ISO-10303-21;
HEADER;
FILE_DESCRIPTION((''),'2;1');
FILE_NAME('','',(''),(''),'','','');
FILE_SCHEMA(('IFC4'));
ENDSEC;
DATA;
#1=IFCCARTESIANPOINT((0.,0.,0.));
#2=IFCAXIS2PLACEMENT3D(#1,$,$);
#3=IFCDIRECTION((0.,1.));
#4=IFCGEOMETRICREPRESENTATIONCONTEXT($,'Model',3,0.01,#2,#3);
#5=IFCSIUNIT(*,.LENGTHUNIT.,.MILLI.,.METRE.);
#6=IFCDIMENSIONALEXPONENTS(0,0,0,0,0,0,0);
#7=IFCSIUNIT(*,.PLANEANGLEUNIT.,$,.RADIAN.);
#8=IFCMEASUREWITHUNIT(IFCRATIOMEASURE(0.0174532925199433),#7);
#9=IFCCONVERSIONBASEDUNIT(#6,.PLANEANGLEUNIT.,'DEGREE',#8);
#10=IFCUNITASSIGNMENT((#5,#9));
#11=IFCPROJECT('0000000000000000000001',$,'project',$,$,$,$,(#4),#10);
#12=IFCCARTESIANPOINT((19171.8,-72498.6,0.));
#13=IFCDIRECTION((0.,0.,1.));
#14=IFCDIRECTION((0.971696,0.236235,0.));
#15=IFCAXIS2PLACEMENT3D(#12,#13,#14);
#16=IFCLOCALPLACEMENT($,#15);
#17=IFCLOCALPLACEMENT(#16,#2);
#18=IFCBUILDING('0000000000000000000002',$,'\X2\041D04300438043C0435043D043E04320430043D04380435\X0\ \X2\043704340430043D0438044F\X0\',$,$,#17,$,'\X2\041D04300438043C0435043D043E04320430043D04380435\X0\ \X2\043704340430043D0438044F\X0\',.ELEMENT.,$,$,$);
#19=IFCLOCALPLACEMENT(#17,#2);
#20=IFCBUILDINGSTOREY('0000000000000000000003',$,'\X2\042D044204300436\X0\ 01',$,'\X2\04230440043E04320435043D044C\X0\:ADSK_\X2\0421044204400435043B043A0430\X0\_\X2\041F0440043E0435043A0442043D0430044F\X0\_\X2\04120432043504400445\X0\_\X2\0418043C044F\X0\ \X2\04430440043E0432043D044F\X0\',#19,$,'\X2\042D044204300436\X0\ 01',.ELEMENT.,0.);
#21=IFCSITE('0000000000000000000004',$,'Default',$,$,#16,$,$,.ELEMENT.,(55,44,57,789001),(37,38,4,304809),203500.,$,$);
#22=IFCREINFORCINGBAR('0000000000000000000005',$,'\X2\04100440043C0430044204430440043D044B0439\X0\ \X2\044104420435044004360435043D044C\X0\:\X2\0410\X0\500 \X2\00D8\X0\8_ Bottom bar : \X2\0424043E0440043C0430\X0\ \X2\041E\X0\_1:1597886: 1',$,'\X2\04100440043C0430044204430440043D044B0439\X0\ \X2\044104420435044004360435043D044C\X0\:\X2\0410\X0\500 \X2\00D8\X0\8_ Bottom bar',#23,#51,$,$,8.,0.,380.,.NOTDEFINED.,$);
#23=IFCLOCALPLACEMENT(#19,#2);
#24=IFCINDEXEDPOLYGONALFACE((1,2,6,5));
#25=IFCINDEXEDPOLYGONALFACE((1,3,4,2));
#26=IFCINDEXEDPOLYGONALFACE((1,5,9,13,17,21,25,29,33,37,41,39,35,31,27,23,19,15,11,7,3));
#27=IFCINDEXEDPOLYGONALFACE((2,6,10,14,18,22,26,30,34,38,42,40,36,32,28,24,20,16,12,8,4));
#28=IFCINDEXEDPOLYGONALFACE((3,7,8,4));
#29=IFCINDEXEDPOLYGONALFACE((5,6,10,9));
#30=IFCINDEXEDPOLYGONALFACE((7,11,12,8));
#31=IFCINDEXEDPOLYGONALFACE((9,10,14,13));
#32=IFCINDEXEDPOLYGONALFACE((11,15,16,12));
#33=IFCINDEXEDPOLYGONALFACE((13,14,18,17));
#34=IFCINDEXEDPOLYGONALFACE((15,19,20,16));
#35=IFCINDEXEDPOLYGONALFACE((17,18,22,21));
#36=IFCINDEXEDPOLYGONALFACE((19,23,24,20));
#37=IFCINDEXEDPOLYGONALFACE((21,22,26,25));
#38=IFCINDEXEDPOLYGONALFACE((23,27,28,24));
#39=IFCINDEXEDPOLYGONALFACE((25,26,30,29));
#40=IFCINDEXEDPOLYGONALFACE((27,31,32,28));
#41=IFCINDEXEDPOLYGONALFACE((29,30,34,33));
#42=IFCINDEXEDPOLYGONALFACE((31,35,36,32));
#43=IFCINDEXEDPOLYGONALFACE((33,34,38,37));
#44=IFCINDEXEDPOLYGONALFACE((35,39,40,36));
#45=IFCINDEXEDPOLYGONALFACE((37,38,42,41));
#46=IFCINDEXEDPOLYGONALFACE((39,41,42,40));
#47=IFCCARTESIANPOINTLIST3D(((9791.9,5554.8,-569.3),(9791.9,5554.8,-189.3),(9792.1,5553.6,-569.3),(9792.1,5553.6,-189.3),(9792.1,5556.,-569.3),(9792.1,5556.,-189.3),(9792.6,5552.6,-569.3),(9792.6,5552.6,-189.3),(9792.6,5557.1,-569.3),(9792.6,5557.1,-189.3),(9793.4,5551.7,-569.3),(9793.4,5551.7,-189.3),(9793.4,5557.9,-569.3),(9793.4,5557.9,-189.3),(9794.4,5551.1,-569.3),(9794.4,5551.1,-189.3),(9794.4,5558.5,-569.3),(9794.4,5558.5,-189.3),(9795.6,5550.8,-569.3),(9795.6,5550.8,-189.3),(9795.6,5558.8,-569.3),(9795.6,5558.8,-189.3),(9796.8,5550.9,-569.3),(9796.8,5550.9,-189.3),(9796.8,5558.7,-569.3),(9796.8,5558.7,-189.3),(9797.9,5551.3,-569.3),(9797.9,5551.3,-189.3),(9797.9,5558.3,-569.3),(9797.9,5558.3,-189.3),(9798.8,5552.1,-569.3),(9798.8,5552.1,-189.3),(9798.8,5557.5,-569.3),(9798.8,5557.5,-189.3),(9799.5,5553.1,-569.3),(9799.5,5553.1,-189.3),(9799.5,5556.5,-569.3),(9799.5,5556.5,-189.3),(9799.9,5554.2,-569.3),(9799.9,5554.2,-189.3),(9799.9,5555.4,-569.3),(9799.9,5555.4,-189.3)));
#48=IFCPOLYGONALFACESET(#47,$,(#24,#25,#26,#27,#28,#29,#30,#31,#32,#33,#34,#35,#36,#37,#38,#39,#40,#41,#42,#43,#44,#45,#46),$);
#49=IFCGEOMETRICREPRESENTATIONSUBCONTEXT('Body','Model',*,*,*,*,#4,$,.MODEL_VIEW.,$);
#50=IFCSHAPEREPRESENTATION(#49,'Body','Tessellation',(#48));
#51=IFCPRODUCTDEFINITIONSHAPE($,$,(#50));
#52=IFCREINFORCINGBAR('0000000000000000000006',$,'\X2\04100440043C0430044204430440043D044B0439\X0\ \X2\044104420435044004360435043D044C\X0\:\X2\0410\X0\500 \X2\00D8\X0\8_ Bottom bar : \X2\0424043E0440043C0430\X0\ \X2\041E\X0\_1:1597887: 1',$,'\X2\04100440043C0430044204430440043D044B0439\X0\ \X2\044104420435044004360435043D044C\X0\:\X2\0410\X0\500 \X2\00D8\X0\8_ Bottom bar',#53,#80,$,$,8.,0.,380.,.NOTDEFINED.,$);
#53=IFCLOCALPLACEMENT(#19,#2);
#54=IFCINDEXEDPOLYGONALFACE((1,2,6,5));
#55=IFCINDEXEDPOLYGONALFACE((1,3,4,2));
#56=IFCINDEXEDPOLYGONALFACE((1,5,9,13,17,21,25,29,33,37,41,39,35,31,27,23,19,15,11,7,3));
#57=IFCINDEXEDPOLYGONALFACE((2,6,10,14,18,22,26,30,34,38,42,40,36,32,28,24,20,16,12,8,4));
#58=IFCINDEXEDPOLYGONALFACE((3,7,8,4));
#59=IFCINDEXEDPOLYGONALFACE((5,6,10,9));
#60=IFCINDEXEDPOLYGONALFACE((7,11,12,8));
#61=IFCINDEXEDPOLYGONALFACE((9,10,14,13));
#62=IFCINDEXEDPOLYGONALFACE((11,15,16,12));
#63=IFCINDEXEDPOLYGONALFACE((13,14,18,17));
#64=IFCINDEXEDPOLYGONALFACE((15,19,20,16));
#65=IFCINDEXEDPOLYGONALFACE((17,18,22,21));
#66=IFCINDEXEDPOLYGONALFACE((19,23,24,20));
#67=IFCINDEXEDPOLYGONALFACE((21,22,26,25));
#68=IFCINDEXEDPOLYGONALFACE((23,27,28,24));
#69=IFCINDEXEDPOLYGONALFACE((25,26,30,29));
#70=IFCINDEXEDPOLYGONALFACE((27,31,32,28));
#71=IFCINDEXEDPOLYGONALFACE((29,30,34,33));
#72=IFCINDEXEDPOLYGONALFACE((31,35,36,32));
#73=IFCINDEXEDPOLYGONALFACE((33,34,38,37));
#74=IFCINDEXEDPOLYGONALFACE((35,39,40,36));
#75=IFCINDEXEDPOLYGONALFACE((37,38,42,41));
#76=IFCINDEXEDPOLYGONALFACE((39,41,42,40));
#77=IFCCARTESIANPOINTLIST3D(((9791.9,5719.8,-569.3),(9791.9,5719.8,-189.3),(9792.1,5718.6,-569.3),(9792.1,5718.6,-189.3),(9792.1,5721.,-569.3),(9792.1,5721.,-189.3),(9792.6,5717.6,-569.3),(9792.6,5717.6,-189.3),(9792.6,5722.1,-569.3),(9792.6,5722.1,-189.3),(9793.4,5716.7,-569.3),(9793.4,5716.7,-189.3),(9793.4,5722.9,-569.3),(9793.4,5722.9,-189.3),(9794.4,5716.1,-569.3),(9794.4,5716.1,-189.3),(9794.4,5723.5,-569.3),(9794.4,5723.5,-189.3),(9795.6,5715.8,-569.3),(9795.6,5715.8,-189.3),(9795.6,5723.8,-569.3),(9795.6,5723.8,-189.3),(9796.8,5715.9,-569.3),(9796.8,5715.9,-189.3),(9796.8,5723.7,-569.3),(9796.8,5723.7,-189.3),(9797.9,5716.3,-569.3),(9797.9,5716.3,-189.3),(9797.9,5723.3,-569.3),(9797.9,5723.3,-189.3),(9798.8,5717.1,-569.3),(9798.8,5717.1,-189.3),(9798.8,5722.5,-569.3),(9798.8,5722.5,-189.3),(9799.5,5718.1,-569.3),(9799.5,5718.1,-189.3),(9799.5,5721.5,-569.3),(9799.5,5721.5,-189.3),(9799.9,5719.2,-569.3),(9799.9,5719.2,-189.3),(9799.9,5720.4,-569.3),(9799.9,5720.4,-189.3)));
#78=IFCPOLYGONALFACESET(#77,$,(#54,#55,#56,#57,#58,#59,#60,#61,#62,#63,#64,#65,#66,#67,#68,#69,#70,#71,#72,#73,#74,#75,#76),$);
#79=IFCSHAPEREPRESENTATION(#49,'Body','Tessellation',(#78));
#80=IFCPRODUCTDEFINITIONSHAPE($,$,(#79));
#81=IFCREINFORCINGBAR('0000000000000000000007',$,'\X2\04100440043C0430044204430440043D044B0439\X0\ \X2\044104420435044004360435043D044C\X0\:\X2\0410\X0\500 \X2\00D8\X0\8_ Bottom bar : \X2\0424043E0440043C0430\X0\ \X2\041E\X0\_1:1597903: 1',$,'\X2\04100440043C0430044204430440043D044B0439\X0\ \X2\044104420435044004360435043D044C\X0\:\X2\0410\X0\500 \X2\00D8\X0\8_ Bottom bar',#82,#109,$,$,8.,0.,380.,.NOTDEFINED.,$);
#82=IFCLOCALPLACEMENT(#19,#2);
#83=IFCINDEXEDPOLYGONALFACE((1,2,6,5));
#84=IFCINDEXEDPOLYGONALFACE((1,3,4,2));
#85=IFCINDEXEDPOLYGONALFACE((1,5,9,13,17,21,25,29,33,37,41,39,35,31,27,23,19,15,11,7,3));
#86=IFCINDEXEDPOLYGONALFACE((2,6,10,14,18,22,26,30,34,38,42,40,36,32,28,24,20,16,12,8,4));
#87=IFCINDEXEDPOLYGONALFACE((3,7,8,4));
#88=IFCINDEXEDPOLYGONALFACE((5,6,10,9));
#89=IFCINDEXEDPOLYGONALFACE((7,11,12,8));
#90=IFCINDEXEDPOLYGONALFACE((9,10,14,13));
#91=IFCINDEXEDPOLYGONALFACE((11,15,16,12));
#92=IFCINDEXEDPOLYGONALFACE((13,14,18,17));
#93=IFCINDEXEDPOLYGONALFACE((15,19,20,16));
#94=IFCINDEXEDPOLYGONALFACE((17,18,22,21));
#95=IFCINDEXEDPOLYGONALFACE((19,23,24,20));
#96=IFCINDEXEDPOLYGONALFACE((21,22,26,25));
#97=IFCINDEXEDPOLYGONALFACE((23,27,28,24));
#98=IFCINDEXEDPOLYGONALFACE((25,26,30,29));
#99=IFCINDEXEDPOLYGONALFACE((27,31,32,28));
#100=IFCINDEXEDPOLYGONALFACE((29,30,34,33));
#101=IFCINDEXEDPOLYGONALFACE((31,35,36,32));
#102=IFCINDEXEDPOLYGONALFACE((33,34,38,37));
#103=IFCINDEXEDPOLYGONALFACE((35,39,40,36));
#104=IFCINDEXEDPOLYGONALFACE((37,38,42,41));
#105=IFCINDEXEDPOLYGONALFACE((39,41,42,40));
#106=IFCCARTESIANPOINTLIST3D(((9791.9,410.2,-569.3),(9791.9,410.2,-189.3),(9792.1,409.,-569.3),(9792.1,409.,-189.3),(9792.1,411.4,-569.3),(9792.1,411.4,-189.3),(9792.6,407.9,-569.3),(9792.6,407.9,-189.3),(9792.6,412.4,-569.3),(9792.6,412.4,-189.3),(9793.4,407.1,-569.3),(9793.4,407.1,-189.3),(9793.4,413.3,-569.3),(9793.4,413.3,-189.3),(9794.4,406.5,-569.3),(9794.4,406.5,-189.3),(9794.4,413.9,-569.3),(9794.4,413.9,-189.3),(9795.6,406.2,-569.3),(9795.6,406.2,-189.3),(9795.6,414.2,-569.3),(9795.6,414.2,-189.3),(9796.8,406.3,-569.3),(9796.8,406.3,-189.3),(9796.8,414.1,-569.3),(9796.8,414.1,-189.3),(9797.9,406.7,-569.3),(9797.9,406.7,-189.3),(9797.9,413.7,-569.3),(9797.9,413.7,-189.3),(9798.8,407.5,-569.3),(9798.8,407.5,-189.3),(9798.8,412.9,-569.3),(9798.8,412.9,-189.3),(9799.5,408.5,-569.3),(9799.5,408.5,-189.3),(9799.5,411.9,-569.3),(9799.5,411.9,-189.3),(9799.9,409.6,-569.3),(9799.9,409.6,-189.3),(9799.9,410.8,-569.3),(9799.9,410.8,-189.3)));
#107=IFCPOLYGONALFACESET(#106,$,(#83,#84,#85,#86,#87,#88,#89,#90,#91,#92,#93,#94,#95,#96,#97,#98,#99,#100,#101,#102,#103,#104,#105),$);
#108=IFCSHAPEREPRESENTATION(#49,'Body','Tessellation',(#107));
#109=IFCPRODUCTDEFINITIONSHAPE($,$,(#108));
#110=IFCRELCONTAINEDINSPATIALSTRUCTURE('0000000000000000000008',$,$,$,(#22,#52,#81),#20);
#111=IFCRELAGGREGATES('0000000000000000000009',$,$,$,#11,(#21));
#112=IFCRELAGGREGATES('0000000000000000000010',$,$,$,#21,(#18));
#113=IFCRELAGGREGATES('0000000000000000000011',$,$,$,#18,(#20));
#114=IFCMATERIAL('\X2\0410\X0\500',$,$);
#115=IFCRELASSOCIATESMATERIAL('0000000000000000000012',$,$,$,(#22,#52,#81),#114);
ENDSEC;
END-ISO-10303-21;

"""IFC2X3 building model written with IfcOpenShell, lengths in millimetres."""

from ifc_helpers import new_model, entity, si_unit, converted_unit, direction, frame, origin, place, context, subcontext, project, spatial, material, element, save


model = new_model("IFC2X3")

# Units and contexts
model_context = context("Model", 3, precision=0.01, world=origin(), true_north=direction((0.0, 1.0)))
body_context = subcontext(model_context, "Body", "Model", "MODEL_VIEW")
ifc_project = project(units=[si_unit("LENGTHUNIT", "METRE", prefix="MILLI"), converted_unit("PLANEANGLEUNIT", "DEGREE", entity("IfcRatioMeasure", 0.0174532925199433), si_unit("PLANEANGLEUNIT", "RADIAN"), dimensions=[0, 0, 0, 0, 0, 0, 0])], contexts=[model_context])

# Site, building, storey
site_placement = place(None, frame((19171.8, -72498.6, 0.0), z_axis=(0.0, 0.0, 1.0), x_axis=(0.971696, 0.236235, 0.0)))
site = spatial("IfcSite", under=ifc_project, at=site_placement, Name="Default", CompositionType="ELEMENT", RefLatitude=(55, 44, 57, 789001), RefLongitude=(37, 38, 4, 304809), RefElevation=203500.0)
building_placement = place(site_placement, origin())
building = spatial("IfcBuilding", under=site, at=building_placement, Name="Наименование здания", LongName="Наименование здания", CompositionType="ELEMENT")
storey_placement = place(building_placement, origin())
storey = spatial("IfcBuildingStorey", under=building, at=storey_placement, Name="Этаж 01", ObjectType="Уровень:ADSK_Стрелка_Проектная_Вверх_Имя уровня", LongName="Этаж 01", CompositionType="ELEMENT", Elevation=0.0)

# Reinforcing bars
ifc_material = material(Name="А500")
placement = place(storey_placement, origin())
element("IfcReinforcingBar", 1, at=placement, inside=storey, material=ifc_material, Name="Арматурный стержень:А500 Ø8_ Bottom bar : Форма О_1:1597886: 1", ObjectType="Арматурный стержень:А500 Ø8_ Bottom bar", BarLength=380.0, BarRole="NOTDEFINED", CrossSectionArea=0.0, NominalDiameter=8.0, context=body_context, shape_type="AdvancedSweptSolid", body=[
    entity("IfcSweptDiskSolid", entity("IfcCompositeCurve", [entity("IfcCompositeCurveSegment", "CONTINUOUS", True, entity("IfcPolyline", [entity("IfcCartesianPoint", [9795.9, 5554.8, -189.3]), entity("IfcCartesianPoint", [9795.9, 5554.8, -569.3])]))], False), 4.0, None, 0.0, 1.0),
])
element("IfcReinforcingBar", 2, at=placement, inside=storey, material=ifc_material, Name="Арматурный стержень:А500 Ø8_ Bottom bar : Форма О_1:1597887: 1", ObjectType="Арматурный стержень:А500 Ø8_ Bottom bar", BarLength=380.0, BarRole="NOTDEFINED", CrossSectionArea=0.0, NominalDiameter=8.0, context=body_context, shape_type="AdvancedSweptSolid", body=[
    entity("IfcSweptDiskSolid", entity("IfcCompositeCurve", [entity("IfcCompositeCurveSegment", "CONTINUOUS", True, entity("IfcPolyline", [entity("IfcCartesianPoint", [9795.9, 5719.8, -189.3]), entity("IfcCartesianPoint", [9795.9, 5719.8, -569.3])]))], False), 4.0, None, 0.0, 1.0),
])
element("IfcReinforcingBar", 3, at=placement, inside=storey, material=ifc_material, Name="Арматурный стержень:А500 Ø8_ Bottom bar : Форма О_1:1597903: 1", ObjectType="Арматурный стержень:А500 Ø8_ Bottom bar", BarLength=380.0, BarRole="NOTDEFINED", CrossSectionArea=0.0, NominalDiameter=8.0, context=body_context, shape_type="AdvancedSweptSolid", body=[
    entity("IfcSweptDiskSolid", entity("IfcCompositeCurve", [entity("IfcCompositeCurveSegment", "CONTINUOUS", True, entity("IfcPolyline", [entity("IfcCartesianPoint", [9795.9, 410.2, -189.3]), entity("IfcCartesianPoint", [9795.9, 410.2, -569.3])]))], False), 4.0, None, 0.0, 1.0),
])

save(model, "model.ifc")
